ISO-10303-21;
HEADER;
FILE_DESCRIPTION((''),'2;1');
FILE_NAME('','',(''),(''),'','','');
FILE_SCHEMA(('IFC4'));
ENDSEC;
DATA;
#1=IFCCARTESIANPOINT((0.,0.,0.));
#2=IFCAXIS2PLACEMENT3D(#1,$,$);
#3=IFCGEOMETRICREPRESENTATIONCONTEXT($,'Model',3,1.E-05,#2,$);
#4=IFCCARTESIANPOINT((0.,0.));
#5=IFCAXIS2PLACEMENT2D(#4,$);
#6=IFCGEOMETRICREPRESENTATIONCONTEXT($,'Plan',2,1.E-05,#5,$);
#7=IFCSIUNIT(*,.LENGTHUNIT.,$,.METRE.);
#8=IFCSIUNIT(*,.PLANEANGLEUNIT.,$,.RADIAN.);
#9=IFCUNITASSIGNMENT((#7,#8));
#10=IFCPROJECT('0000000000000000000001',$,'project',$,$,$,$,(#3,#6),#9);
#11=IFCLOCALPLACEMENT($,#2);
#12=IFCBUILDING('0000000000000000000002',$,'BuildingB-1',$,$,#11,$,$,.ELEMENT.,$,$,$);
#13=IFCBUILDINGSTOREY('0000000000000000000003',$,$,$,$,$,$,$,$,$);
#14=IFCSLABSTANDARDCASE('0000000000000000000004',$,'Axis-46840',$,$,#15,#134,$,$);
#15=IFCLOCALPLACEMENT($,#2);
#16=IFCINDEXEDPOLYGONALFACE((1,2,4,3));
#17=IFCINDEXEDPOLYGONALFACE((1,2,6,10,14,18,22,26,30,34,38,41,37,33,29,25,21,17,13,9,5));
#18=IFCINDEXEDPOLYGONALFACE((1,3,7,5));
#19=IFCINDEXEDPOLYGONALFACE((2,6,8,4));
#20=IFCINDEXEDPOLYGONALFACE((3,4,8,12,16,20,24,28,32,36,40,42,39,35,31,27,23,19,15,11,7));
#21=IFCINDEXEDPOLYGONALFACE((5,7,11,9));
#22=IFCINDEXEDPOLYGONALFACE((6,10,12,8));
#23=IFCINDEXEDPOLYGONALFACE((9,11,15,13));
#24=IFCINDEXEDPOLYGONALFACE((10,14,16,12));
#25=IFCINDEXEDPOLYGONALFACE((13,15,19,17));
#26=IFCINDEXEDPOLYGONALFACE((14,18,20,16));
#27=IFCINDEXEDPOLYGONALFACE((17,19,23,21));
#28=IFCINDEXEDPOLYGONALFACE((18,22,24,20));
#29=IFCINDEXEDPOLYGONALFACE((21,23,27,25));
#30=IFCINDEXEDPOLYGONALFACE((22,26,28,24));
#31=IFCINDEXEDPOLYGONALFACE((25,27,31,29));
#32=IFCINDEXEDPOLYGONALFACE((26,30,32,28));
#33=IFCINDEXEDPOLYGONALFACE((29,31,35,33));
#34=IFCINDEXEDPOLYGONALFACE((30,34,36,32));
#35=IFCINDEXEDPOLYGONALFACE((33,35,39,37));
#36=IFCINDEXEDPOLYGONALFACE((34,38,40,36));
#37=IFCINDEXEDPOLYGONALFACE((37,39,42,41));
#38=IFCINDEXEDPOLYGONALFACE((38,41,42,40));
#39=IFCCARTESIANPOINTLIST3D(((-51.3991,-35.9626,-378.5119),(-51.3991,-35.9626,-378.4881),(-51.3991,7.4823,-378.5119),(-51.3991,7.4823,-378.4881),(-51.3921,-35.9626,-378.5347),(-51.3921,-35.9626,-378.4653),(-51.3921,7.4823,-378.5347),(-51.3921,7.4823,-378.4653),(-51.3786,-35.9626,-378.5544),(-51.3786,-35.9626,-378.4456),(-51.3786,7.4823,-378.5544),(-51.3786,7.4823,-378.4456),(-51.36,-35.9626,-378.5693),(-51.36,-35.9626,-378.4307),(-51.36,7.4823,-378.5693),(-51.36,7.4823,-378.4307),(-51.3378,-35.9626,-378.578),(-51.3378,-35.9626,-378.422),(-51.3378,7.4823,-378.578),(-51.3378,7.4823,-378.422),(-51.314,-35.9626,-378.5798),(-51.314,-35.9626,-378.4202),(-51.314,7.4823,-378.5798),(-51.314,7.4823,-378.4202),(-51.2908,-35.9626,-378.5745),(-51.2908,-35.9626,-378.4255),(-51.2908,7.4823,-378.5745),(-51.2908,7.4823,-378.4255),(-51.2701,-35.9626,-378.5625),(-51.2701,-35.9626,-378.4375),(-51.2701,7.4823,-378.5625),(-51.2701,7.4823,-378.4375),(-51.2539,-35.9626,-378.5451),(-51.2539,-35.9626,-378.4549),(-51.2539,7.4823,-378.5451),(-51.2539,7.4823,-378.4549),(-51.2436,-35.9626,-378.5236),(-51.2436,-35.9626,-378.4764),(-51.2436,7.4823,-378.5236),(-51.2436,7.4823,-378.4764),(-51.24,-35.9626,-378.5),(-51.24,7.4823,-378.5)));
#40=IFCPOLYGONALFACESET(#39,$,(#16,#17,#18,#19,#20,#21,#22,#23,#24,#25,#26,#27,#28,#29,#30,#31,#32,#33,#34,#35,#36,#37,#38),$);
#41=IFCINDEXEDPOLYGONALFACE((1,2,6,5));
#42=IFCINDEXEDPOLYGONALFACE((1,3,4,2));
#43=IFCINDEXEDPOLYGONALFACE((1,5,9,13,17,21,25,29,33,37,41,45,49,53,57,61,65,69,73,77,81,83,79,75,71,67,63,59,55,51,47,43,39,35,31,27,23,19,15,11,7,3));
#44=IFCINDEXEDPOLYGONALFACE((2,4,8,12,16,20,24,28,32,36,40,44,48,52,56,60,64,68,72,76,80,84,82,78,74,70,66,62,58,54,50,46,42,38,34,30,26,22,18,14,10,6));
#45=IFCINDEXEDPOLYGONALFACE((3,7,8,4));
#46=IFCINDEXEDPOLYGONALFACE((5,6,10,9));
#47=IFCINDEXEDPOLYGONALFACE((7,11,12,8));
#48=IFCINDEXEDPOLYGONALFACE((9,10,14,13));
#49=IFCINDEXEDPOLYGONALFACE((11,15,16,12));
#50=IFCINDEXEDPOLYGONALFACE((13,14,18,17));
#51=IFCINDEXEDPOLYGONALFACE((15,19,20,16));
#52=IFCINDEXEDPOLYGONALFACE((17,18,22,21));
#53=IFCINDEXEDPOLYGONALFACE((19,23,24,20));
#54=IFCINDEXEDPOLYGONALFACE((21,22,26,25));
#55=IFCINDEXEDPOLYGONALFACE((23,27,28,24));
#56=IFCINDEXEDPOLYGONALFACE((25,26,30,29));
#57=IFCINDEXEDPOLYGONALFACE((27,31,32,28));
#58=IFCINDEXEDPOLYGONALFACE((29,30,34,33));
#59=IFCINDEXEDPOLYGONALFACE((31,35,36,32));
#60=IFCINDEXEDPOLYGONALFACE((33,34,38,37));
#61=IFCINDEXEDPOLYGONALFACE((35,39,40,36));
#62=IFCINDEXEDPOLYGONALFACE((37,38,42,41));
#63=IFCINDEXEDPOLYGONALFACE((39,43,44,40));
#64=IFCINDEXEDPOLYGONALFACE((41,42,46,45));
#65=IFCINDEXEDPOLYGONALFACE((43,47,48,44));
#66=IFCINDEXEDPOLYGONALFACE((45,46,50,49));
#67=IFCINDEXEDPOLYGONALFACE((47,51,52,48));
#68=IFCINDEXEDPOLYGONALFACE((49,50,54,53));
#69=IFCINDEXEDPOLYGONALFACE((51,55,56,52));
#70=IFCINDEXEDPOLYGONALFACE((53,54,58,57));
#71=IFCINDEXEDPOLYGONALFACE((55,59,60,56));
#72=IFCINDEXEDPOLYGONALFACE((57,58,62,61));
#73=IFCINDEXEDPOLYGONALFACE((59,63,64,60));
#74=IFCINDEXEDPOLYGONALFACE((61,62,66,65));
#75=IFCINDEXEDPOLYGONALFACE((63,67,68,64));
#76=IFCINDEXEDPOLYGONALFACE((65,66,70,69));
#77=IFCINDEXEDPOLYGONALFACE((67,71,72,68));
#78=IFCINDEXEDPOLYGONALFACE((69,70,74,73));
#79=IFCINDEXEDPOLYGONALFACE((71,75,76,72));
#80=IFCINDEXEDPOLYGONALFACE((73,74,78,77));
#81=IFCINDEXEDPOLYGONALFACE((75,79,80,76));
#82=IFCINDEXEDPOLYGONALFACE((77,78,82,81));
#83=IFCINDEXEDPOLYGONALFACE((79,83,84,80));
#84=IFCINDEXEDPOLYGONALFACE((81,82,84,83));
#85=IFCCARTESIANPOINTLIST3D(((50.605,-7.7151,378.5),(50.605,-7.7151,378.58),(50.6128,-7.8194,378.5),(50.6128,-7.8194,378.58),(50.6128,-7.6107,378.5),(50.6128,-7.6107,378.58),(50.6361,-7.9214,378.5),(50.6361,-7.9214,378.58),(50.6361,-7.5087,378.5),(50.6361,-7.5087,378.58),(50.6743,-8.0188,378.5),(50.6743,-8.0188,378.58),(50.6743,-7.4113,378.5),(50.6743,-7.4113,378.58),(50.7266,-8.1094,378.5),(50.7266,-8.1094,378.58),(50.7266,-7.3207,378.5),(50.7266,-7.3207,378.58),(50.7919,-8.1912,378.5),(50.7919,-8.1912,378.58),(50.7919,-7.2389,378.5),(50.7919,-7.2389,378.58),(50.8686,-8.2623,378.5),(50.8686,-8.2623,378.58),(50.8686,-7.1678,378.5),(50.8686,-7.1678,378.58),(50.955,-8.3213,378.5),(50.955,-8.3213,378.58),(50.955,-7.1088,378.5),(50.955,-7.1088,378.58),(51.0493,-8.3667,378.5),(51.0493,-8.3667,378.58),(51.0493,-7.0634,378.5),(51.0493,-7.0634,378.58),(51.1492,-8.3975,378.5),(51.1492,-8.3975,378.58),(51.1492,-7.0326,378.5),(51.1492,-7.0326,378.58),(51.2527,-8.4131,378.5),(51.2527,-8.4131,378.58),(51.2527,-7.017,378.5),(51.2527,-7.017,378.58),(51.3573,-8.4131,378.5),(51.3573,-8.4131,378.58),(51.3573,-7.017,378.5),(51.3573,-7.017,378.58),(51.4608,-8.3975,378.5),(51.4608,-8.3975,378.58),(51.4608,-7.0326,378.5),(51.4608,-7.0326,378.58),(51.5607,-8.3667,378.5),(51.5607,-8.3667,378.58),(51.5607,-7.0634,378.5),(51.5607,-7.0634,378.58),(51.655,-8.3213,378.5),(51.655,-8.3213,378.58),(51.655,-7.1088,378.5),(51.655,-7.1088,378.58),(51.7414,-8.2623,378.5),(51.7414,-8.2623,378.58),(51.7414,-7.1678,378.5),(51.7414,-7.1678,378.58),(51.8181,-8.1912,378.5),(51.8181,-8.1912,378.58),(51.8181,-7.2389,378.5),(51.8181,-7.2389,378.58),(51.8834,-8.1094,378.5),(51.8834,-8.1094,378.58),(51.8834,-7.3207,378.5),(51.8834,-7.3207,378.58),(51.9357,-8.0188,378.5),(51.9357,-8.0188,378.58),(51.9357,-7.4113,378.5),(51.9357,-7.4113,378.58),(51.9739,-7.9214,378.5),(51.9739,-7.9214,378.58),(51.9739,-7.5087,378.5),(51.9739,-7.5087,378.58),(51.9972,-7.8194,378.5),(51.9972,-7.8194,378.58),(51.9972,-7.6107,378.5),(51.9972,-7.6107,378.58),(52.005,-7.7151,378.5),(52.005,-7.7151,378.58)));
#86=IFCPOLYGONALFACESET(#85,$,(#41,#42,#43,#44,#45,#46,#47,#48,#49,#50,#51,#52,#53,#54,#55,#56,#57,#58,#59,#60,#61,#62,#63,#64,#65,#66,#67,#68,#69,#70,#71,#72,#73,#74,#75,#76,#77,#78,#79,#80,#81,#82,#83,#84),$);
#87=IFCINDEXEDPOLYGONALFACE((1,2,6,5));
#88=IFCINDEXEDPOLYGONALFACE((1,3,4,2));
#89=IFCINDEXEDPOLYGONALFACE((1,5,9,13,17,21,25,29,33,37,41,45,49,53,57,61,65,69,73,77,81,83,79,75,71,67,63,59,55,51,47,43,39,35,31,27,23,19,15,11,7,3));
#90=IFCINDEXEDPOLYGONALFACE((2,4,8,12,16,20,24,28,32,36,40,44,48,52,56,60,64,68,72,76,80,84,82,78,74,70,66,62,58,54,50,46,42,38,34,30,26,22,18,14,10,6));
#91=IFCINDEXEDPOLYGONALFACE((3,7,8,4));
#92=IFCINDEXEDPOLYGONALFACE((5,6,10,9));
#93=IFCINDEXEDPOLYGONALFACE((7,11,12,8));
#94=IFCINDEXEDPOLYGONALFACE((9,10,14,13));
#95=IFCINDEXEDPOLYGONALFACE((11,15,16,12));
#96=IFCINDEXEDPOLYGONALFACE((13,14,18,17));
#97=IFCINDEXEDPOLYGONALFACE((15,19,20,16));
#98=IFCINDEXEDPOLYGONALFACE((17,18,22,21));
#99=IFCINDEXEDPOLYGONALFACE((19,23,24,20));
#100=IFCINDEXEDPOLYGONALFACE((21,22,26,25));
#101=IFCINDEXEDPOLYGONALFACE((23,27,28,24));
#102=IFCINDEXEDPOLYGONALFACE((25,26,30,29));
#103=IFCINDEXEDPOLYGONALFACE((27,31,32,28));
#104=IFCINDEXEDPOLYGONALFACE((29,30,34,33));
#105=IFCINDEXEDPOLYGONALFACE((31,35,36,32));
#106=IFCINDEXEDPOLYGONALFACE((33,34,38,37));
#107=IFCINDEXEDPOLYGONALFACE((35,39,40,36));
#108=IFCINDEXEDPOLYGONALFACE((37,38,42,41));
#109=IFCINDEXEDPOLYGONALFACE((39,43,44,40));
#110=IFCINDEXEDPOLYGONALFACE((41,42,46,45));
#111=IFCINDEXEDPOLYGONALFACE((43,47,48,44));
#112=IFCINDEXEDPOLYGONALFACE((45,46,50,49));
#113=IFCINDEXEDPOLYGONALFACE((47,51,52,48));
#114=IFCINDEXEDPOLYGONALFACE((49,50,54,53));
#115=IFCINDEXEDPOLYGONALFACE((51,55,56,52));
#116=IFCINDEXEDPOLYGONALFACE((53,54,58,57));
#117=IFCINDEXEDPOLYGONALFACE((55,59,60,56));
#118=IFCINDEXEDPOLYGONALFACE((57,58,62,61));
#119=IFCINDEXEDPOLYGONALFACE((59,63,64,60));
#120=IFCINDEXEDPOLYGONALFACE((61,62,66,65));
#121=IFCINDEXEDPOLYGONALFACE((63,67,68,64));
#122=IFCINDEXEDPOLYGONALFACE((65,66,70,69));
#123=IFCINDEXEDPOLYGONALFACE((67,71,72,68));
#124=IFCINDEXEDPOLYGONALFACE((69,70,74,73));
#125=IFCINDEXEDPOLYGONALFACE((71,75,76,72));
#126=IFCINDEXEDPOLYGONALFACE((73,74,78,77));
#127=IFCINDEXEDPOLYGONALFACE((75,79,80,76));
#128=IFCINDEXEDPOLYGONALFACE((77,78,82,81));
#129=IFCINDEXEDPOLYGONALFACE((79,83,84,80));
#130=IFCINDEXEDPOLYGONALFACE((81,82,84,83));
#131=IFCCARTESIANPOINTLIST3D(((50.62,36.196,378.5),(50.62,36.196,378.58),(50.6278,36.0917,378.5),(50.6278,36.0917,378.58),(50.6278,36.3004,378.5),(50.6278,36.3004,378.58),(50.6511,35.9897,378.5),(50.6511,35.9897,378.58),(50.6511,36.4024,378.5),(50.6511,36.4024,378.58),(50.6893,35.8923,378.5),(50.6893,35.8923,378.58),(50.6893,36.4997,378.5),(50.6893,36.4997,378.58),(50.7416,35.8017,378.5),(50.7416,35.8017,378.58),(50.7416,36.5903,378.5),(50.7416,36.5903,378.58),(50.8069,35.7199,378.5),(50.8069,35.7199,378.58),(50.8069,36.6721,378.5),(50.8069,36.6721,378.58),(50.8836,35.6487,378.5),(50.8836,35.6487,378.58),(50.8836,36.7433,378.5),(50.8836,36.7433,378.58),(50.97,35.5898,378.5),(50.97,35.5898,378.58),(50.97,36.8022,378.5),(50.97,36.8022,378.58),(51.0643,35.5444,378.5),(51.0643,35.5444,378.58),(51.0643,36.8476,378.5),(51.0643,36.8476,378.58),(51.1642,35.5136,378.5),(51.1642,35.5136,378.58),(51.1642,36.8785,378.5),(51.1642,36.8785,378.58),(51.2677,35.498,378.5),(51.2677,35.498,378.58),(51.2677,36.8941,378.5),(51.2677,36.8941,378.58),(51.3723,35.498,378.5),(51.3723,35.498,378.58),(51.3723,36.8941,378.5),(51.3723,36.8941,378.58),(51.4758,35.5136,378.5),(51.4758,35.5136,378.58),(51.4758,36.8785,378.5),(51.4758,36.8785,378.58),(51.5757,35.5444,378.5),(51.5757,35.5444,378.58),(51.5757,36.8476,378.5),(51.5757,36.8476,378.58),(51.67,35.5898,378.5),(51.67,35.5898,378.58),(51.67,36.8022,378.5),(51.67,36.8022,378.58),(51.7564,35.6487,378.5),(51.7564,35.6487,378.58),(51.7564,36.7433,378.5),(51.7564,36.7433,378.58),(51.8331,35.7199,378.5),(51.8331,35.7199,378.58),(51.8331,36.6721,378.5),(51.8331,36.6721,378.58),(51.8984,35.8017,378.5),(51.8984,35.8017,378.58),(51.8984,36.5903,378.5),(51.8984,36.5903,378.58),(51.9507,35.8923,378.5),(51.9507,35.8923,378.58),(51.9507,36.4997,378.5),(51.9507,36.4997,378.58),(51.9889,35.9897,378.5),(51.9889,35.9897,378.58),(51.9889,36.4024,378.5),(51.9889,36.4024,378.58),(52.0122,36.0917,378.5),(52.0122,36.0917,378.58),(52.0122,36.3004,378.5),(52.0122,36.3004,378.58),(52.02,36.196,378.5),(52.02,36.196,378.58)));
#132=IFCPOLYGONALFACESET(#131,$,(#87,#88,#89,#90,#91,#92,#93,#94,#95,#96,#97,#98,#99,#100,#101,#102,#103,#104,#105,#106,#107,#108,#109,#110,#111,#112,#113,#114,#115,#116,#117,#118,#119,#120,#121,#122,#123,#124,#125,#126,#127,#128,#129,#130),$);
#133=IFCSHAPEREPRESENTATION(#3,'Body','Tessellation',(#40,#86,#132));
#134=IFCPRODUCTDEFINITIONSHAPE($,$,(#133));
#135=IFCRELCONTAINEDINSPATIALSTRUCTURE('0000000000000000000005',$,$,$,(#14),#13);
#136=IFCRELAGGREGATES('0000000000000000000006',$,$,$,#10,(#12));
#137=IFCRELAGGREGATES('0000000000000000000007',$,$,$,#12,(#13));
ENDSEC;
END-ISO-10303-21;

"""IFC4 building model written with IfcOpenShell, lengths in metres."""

from ifc_helpers import new_model, entity, si_unit, frame, origin, origin_2d, place, context, project, spatial, circle, extrude, element, save


model = new_model("IFC4")

# Units and contexts
model_context = context("Model", 3, precision=1e-05, world=origin())
plan_context = context("Plan", 2, precision=1e-05, world=origin_2d())
ifc_project = project(units=[si_unit("LENGTHUNIT", "METRE"), si_unit("PLANEANGLEUNIT", "RADIAN")], contexts=[model_context, plan_context])

# Building, storey
building_placement = place(None, origin())
building = spatial("IfcBuilding", under=ifc_project, at=building_placement, Name="BuildingB-1", CompositionType="ELEMENT")
storey = spatial("IfcBuildingStorey", under=building)

# Slab
element("IfcSlabStandardCase", 1, inside=storey, Name="Axis-46840", context=model_context, shape_type="AdvancedSweptSolid", body=[
    entity("IfcSurfaceCurveSweptAreaSolid", entity("IfcCircleProfileDef", "AREA", None, None, 0.08), None, entity("IfcPolyline", [entity("IfcCartesianPoint", [51.32, -7.4823, 378.5]), entity("IfcCartesianPoint", [51.32, 35.9626, 378.5])]), None, None, entity("IfcPlane", entity("IfcAxis2Placement3D", entity("IfcCartesianPoint", [51.32, -7.4823, 378.5]), entity("IfcDirection", [0.0, 0.0, 1.0]), entity("IfcDirection", [1.0, 0.0, 0.0])))),
    extrude(circle(Radius=0.7), frame((51.305, -7.7151, 378.5)), (0.0, 0.0, 1.0), 0.08),
    extrude(circle(Radius=0.7), frame((51.32, 36.196, 378.5)), (0.0, 0.0, 1.0), 0.08),
])

save(model, "model.ifc")
